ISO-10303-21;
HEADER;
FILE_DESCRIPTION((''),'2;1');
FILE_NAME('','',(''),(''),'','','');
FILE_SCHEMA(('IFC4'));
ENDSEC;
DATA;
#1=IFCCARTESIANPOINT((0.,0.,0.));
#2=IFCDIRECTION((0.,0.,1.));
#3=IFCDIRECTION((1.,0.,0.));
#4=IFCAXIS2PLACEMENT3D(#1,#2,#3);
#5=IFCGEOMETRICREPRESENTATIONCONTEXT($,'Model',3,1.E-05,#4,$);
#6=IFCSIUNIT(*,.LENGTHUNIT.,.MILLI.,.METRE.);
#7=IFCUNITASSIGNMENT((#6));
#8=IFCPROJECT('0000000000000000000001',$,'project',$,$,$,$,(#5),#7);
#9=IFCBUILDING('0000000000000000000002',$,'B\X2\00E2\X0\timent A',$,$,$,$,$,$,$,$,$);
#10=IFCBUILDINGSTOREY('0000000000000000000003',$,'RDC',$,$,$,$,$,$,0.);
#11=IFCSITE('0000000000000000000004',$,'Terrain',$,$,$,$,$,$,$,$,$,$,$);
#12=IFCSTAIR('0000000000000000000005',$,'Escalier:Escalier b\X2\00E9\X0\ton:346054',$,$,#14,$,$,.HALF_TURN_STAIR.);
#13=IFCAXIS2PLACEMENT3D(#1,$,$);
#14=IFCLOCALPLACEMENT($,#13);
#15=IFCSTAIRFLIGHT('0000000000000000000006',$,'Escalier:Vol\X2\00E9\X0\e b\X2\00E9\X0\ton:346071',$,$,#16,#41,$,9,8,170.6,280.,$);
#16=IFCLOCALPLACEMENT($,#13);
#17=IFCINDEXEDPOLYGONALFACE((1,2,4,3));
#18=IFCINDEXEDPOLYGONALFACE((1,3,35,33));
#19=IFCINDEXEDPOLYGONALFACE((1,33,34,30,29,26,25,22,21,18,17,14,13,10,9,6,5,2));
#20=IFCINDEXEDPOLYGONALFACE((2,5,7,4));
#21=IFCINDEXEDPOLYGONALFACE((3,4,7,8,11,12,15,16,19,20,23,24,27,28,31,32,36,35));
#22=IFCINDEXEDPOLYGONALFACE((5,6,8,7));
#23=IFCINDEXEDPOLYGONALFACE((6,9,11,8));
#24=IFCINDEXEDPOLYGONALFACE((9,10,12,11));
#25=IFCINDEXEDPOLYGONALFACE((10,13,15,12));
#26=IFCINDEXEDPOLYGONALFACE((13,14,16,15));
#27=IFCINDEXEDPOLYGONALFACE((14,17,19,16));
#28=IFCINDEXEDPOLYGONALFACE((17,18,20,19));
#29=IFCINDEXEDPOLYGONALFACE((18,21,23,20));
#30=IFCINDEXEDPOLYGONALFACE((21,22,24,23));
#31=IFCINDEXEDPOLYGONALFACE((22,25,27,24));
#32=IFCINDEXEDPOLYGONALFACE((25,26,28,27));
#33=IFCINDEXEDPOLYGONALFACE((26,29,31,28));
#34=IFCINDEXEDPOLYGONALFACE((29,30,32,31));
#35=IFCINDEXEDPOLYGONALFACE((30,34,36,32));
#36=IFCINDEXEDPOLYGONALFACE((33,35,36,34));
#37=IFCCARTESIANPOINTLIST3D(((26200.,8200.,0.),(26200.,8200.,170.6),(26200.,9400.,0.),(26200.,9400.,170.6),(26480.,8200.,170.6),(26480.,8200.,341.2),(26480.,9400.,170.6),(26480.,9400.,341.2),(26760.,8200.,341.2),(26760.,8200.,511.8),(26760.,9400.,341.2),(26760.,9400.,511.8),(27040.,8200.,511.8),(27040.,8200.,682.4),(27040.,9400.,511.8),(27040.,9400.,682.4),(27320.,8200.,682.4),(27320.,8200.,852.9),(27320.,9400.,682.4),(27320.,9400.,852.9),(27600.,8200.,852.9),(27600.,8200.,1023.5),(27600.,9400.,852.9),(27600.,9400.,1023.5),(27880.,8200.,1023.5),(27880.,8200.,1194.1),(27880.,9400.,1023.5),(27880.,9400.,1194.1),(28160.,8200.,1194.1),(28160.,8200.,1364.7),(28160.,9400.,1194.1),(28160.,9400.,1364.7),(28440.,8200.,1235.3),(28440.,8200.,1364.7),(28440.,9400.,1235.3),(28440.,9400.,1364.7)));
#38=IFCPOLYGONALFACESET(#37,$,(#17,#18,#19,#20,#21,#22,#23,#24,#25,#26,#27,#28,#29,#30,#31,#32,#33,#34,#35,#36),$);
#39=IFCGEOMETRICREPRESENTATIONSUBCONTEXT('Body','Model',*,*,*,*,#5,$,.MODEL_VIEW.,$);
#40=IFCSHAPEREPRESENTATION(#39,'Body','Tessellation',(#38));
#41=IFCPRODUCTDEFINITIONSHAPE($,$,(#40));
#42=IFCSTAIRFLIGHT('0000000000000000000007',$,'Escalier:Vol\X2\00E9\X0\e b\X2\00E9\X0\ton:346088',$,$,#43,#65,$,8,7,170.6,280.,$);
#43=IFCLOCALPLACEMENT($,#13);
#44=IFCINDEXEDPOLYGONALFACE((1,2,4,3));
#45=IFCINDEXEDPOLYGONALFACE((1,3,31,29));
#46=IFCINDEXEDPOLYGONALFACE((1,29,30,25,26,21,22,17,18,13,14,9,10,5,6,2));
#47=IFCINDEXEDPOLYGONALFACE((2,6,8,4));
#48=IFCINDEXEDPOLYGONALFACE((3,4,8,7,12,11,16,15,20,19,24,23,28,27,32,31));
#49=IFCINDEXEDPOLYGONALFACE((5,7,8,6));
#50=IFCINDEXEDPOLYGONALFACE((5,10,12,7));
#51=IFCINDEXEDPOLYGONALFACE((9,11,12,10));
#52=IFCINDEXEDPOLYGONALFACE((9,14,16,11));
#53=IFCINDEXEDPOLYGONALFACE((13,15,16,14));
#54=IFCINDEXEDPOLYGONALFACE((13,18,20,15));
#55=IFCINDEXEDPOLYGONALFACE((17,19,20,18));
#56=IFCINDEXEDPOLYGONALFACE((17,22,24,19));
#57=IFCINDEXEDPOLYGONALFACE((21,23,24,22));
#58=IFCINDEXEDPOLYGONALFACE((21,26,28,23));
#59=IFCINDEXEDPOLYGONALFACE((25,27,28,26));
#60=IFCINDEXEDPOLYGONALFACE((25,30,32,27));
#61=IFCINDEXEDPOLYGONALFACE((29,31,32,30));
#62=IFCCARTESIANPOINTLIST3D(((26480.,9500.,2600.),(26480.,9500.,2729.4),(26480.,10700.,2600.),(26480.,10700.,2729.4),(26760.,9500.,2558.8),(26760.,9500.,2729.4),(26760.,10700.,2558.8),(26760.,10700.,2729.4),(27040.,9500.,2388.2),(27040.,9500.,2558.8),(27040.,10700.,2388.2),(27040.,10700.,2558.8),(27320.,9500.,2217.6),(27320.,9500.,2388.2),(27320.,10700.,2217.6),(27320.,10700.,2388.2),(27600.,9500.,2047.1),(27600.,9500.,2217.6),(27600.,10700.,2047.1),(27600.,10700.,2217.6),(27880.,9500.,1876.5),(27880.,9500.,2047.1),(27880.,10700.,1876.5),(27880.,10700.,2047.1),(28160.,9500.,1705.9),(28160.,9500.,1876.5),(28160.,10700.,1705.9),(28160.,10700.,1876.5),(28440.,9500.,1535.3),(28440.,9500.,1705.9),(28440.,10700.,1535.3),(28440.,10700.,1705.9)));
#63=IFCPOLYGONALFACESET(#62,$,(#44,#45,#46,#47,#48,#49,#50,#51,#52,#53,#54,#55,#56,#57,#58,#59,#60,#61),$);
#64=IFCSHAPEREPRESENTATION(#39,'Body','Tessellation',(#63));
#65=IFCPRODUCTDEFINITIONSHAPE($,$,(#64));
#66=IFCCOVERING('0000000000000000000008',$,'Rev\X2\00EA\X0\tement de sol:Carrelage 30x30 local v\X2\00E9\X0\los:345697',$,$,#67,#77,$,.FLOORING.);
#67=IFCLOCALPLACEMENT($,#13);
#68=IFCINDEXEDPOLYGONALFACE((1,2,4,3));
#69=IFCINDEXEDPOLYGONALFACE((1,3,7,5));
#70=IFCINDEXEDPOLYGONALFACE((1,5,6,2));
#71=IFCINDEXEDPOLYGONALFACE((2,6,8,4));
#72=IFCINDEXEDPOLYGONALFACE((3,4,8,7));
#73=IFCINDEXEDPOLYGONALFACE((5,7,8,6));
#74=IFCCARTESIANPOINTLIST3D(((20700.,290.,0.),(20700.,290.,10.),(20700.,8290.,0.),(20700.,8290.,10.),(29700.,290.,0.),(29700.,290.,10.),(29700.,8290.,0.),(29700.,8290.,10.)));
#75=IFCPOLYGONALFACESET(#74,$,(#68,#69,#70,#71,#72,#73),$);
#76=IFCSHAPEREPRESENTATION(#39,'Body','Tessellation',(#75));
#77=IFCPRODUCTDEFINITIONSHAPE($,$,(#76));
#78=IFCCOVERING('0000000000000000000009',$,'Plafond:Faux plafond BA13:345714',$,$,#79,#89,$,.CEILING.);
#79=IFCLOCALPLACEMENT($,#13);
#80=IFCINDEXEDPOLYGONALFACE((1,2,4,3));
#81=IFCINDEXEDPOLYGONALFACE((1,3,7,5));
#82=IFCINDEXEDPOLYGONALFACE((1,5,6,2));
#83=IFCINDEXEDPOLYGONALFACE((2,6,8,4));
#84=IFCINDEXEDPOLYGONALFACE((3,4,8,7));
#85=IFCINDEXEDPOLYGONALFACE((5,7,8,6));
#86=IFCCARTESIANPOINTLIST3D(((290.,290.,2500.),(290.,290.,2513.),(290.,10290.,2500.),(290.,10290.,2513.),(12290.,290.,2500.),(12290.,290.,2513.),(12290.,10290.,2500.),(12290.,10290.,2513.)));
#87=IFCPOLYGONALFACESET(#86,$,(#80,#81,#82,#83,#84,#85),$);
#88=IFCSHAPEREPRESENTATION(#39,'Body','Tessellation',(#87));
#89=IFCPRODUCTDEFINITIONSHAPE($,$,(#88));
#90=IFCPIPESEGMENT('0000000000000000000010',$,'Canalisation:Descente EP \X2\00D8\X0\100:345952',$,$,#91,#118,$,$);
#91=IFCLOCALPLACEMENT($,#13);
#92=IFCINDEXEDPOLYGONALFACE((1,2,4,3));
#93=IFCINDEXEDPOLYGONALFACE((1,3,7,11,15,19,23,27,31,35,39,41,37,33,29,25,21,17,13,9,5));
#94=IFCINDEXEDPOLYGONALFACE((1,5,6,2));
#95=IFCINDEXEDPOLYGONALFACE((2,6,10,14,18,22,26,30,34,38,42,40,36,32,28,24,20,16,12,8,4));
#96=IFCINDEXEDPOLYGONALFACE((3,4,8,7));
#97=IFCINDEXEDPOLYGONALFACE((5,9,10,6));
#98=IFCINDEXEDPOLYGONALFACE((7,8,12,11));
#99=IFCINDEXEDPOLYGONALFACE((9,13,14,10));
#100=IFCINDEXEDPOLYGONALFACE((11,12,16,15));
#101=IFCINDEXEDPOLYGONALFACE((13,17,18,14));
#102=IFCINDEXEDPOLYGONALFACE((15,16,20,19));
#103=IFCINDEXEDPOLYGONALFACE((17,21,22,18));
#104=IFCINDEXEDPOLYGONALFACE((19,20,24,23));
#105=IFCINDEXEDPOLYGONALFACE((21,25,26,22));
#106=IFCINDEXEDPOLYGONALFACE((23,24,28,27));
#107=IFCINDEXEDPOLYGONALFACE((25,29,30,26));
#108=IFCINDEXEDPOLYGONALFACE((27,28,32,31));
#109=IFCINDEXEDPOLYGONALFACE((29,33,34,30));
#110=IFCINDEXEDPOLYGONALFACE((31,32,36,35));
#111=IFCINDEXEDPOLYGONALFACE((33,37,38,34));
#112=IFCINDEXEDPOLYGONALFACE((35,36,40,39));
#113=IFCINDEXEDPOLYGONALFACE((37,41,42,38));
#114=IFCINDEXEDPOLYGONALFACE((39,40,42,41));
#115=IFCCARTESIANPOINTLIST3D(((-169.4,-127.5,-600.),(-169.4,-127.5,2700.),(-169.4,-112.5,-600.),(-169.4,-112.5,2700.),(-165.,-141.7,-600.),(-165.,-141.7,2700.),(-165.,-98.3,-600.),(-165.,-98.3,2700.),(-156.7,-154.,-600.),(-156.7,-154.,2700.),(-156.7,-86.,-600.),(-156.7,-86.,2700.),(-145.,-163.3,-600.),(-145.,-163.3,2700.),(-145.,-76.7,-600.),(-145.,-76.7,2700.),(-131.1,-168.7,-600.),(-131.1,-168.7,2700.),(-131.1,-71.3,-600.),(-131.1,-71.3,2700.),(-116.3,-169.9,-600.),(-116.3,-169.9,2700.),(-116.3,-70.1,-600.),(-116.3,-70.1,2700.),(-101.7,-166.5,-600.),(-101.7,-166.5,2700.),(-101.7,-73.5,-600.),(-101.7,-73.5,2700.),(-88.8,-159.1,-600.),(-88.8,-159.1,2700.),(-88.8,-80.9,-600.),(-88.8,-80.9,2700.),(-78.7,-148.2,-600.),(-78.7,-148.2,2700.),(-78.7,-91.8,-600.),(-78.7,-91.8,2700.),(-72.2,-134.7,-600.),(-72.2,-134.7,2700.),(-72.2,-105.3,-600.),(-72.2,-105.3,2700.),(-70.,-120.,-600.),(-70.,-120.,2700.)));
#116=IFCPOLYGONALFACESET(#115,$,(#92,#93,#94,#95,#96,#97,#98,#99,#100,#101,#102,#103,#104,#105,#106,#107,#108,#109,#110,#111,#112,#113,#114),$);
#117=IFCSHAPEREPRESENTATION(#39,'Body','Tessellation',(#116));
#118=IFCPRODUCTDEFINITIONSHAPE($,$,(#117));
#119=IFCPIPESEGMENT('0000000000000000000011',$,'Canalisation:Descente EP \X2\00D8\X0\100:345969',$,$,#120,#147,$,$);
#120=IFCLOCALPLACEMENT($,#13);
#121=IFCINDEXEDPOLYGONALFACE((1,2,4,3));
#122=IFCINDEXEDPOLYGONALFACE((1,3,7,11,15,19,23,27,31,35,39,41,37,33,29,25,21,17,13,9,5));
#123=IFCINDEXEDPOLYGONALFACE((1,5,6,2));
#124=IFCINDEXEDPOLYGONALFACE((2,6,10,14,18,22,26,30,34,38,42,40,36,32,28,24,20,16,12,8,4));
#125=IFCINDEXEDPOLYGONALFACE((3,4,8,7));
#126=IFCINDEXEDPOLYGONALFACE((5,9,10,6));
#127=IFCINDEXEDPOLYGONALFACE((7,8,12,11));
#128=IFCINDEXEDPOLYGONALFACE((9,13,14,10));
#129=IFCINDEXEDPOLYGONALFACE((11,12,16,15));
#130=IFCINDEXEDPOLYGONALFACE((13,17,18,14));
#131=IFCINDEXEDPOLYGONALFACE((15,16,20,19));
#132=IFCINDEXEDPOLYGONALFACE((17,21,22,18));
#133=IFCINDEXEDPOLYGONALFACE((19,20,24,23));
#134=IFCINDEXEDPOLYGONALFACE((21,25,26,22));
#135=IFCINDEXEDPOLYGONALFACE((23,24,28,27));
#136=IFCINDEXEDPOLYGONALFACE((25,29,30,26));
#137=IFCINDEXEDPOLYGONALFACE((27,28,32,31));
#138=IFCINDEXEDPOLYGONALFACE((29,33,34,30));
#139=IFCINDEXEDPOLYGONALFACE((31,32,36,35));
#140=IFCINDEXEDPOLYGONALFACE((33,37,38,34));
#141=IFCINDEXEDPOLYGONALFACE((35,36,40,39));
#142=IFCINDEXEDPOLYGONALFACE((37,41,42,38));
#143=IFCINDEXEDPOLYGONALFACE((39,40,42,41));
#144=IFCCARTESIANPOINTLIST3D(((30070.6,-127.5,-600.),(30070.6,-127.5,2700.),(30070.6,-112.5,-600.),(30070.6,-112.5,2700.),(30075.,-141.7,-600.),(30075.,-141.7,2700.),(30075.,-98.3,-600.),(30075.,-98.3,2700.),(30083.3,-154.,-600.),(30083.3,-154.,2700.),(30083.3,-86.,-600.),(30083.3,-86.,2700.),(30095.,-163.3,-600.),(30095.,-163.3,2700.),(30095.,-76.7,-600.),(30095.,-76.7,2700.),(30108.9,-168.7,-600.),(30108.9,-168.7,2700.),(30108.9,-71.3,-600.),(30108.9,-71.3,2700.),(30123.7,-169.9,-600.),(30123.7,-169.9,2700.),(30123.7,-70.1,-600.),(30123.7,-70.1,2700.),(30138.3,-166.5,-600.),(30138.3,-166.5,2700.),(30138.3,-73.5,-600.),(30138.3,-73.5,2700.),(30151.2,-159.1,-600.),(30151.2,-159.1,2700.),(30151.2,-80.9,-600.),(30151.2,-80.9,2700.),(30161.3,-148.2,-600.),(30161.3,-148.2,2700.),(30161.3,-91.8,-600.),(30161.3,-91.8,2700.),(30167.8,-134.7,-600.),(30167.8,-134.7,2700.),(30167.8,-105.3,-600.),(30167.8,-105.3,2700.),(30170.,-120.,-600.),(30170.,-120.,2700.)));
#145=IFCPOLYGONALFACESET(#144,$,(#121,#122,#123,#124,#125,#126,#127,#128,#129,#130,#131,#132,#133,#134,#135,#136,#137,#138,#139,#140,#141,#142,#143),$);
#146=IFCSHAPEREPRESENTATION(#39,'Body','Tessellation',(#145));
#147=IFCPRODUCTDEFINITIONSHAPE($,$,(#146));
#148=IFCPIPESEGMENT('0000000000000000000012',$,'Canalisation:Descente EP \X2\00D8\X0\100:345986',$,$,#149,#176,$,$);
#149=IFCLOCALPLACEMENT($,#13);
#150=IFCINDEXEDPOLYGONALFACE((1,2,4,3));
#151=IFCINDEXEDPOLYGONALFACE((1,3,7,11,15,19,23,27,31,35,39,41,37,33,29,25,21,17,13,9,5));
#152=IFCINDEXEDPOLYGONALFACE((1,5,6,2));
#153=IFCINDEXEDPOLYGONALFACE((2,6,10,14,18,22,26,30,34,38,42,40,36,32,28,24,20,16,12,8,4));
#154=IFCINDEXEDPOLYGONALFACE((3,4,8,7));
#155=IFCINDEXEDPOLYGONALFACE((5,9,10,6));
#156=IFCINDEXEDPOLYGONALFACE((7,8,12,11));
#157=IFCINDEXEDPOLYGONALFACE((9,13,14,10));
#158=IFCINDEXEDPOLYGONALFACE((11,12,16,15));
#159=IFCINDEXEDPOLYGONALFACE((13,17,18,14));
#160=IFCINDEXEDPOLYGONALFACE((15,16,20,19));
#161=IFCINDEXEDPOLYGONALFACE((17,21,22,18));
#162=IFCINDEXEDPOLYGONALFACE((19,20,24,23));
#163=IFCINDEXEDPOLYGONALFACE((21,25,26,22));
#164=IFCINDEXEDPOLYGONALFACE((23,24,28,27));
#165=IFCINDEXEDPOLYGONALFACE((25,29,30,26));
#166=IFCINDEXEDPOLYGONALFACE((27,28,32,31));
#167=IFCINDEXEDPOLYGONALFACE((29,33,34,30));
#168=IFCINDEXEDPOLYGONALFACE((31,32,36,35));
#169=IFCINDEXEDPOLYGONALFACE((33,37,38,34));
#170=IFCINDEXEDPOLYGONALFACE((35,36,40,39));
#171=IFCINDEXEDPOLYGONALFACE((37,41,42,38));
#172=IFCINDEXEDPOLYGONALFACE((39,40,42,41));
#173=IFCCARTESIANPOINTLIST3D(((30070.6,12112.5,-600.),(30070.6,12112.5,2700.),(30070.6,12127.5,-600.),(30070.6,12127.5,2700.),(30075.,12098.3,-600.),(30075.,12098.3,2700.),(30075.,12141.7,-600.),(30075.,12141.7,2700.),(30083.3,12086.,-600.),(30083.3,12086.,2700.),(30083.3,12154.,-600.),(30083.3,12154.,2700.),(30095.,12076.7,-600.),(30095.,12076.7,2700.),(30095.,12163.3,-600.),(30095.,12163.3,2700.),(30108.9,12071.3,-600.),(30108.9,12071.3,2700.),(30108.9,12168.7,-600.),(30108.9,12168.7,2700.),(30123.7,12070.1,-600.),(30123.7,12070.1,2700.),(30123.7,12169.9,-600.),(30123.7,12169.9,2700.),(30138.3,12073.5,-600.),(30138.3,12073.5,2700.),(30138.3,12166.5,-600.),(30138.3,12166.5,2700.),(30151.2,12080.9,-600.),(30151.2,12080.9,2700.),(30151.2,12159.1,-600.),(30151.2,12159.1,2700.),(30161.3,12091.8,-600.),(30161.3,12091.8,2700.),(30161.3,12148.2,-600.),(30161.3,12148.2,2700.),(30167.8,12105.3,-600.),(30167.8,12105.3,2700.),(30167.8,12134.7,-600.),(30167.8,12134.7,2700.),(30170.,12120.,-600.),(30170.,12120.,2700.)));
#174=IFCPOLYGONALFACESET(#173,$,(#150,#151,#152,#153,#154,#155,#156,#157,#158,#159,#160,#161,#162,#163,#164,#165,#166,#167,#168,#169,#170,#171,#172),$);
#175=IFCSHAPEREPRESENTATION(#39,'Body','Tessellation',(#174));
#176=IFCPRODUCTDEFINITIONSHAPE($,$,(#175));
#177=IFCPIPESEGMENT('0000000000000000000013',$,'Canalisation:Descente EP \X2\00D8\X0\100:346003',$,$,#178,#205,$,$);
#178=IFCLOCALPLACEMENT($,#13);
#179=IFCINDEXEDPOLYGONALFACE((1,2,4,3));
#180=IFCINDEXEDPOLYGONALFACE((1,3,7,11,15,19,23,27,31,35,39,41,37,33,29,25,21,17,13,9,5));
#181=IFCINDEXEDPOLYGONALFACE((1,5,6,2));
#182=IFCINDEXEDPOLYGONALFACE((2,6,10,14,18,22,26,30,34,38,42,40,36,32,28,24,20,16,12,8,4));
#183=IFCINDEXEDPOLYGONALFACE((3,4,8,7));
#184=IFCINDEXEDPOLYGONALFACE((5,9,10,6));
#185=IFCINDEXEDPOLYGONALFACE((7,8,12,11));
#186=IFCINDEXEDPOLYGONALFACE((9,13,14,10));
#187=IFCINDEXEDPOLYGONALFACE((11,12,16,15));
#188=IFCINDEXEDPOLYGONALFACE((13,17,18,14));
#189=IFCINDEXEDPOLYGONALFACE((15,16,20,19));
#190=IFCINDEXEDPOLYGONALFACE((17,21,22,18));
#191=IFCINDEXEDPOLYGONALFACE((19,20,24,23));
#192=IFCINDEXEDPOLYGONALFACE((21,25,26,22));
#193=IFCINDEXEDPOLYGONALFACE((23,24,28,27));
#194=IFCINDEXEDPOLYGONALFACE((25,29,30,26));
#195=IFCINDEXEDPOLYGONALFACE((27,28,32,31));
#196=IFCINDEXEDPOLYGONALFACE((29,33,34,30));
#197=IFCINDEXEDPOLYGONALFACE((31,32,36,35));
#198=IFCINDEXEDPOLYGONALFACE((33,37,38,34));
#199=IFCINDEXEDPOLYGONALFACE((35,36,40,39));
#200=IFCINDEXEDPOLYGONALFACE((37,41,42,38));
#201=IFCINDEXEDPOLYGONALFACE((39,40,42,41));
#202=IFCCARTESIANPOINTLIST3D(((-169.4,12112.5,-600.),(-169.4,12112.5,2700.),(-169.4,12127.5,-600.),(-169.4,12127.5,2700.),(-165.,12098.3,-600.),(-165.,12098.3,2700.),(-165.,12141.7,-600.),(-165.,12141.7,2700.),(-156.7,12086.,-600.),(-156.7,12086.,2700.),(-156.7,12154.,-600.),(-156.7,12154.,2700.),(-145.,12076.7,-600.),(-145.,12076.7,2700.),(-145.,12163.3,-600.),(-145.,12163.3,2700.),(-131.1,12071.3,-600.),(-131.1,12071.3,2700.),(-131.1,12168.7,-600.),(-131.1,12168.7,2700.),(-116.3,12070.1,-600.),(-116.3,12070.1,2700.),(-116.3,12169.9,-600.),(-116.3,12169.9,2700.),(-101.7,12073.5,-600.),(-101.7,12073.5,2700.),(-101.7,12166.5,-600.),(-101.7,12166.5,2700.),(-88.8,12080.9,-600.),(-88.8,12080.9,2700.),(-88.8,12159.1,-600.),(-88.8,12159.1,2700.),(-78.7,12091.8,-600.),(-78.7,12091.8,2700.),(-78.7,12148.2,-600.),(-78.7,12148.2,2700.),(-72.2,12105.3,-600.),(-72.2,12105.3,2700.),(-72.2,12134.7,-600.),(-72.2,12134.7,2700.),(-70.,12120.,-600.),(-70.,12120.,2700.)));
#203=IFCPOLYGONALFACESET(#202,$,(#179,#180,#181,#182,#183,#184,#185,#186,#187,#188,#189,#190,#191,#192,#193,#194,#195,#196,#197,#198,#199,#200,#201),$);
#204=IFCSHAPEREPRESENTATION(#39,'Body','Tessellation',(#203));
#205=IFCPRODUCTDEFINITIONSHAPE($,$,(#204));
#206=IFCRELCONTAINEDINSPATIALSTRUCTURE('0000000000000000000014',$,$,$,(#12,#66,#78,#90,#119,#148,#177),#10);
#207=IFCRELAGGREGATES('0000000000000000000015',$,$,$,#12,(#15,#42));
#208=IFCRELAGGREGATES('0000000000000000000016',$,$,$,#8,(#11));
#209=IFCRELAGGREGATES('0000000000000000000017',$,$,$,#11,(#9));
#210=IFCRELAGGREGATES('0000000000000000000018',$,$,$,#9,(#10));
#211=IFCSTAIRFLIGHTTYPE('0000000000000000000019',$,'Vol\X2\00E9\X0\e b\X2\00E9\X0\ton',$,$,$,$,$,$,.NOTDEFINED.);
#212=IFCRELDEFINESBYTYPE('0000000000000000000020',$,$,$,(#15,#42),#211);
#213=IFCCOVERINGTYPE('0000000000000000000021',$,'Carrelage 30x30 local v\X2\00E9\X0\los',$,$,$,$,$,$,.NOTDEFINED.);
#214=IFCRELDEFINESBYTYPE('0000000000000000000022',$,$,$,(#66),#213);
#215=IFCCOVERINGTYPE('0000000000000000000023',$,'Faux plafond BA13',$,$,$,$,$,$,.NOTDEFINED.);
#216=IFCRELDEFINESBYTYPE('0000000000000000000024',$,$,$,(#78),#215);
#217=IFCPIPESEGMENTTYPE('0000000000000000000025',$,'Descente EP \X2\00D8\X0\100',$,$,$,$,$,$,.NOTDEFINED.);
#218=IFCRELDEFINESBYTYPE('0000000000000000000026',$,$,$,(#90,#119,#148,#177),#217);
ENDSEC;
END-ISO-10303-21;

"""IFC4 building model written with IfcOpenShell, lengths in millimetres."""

from ifc_helpers import new_model, si_unit, frame, frame_2d, origin_with_axes, origin_2d, place, context, subcontext, project, spatial, polyline, rectangle, circle, outline, extrude, type_object, element, aggregate, save


model = new_model("IFC4")

# Units and contexts
model_context = context("Model", 3, precision=1e-05, world=origin_with_axes())
body_context = subcontext(model_context, "Body", "Model", "MODEL_VIEW")
ifc_project = project(units=[si_unit("LENGTHUNIT", "METRE", prefix="MILLI")], contexts=[model_context])

# Site, building, storey
site = spatial("IfcSite", under=ifc_project, Name="Terrain")
building = spatial("IfcBuilding", under=site, Name="Bâtiment A")
storey = spatial("IfcBuildingStorey", under=building, Name="RDC", Elevation=0.0)

# Stair, stair flights
stair = element("IfcStair", 1, inside=storey, Name="Escalier:Escalier béton:346054", PredefinedType="HALF_TURN_STAIR")
stair_flight_type = type_object("IfcStairFlightType", Name="Volée béton", PredefinedType="NOTDEFINED")
stair_flight_1_placement = place(None, origin_with_axes())
stair_flight_1 = element("IfcStairFlight", 2, at=stair_flight_1_placement, type_object=stair_flight_type, Name="Escalier:Volée béton:346071", NumberOfRisers=9, NumberOfTreads=8, RiserHeight=170.6, TreadLength=280.0, context=body_context, shape_type="SweptSolid", body=[
    extrude(outline(polyline([(0.0, 0.0), (0.0, 170.6), (280.0, 170.6), (280.0, 341.2), (560.0, 341.2), (560.0, 511.8), (840.0, 511.8), (840.0, 682.4), (1120.0, 682.4), (1120.0, 852.9), (1400.0, 852.9), (1400.0, 1023.5), (1680.0, 1023.5), (1680.0, 1194.1), (1960.0, 1194.1), (1960.0, 1364.7), (2240.0, 1364.7), (2240.0, 1535.3), (2240.0, 1235.3), (0.0, 0.0)])), frame((26200.0, 9400.0, 0.0), z_axis=(0.0, -1.0, 0.0), x_axis=(1.0, 0.0, 0.0)), (0.0, 0.0, 1.0), 1200.0),
])
stair_flight_2_placement = place(None, origin_with_axes())
stair_flight_2 = element("IfcStairFlight", 3, at=stair_flight_2_placement, type_object=stair_flight_type, Name="Escalier:Volée béton:346088", NumberOfRisers=8, NumberOfTreads=7, RiserHeight=170.6, TreadLength=280.0, context=body_context, shape_type="SweptSolid", body=[
    extrude(outline(polyline([(0.0, 0.0), (0.0, 170.6), (280.0, 170.6), (280.0, 341.2), (560.0, 341.2), (560.0, 511.8), (840.0, 511.8), (840.0, 682.4), (1120.0, 682.4), (1120.0, 852.9), (1400.0, 852.9), (1400.0, 1023.5), (1680.0, 1023.5), (1680.0, 1194.1), (1960.0, 1194.1), (1960.0, 1364.7), (1960.0, 1064.7), (0.0, 0.0)])), frame((28440.0, 9500.0, 1535.3), z_axis=(0.0, 1.0, 0.0), x_axis=(-1.0, 0.0, 0.0)), (0.0, 0.0, 1.0), 1200.0),
])
aggregate(stair, [stair_flight_1, stair_flight_2])

# Coverings
covering_type_1 = type_object("IfcCoveringType", Name="Carrelage 30x30 local vélos", PredefinedType="NOTDEFINED")
covering_1_placement = place(None, origin_with_axes())
element("IfcCovering", 4, at=covering_1_placement, inside=storey, type_object=covering_type_1, Name="Revêtement de sol:Carrelage 30x30 local vélos:345697", PredefinedType="FLOORING", context=body_context, shape_type="SweptSolid", body=[
    extrude(rectangle(XDim=9000.0, YDim=8000.0, at=frame_2d((25200.0, 4290.0))), origin_with_axes(), (0.0, 0.0, 1.0), 10.0),
])
covering_type_2 = type_object("IfcCoveringType", Name="Faux plafond BA13", PredefinedType="NOTDEFINED")
covering_2_placement = place(None, origin_with_axes())
element("IfcCovering", 5, at=covering_2_placement, inside=storey, type_object=covering_type_2, Name="Plafond:Faux plafond BA13:345714", PredefinedType="CEILING", context=body_context, shape_type="SweptSolid", body=[
    extrude(rectangle(XDim=12000.0, YDim=10000.0, at=frame_2d((6290.0, 5290.0))), frame((0.0, 0.0, 2500.0), z_axis=(0.0, 0.0, 1.0), x_axis=(1.0, 0.0, 0.0)), (0.0, 0.0, 1.0), 13.0),
])

# Pipe segments
pipe_segment_type_1 = type_object("IfcPipeSegmentType", Name="Descente EP Ø100", PredefinedType="NOTDEFINED")
pipe_segment_1_placement = place(None, origin_with_axes())
element("IfcPipeSegment", 6, at=pipe_segment_1_placement, inside=storey, type_object=pipe_segment_type_1, Name="Canalisation:Descente EP Ø100:345952", context=body_context, shape_type="SweptSolid", body=[
    extrude(circle(Radius=50.0, at=origin_2d()), frame((-120.0, -120.0, -600.0), z_axis=(0.0, 0.0, 1.0), x_axis=(1.0, 0.0, 0.0)), (0.0, 0.0, 1.0), 3300.0),
])
pipe_segment_2_placement = place(None, origin_with_axes())
element("IfcPipeSegment", 7, at=pipe_segment_2_placement, inside=storey, type_object=pipe_segment_type_1, Name="Canalisation:Descente EP Ø100:345969", context=body_context, shape_type="SweptSolid", body=[
    extrude(circle(Radius=50.0, at=origin_2d()), frame((30120.0, -120.0, -600.0), z_axis=(0.0, 0.0, 1.0), x_axis=(1.0, 0.0, 0.0)), (0.0, 0.0, 1.0), 3300.0),
])
pipe_segment_3_placement = place(None, origin_with_axes())
element("IfcPipeSegment", 8, at=pipe_segment_3_placement, inside=storey, type_object=pipe_segment_type_1, Name="Canalisation:Descente EP Ø100:345986", context=body_context, shape_type="SweptSolid", body=[
    extrude(circle(Radius=50.0, at=origin_2d()), frame((30120.0, 12120.0, -600.0), z_axis=(0.0, 0.0, 1.0), x_axis=(1.0, 0.0, 0.0)), (0.0, 0.0, 1.0), 3300.0),
])
pipe_segment_4_placement = place(None, origin_with_axes())
element("IfcPipeSegment", 9, at=pipe_segment_4_placement, inside=storey, type_object=pipe_segment_type_1, Name="Canalisation:Descente EP Ø100:346003", context=body_context, shape_type="SweptSolid", body=[
    extrude(circle(Radius=50.0, at=origin_2d()), frame((-120.0, 12120.0, -600.0), z_axis=(0.0, 0.0, 1.0), x_axis=(1.0, 0.0, 0.0)), (0.0, 0.0, 1.0), 3300.0),
])

save(model, "model.ifc")
